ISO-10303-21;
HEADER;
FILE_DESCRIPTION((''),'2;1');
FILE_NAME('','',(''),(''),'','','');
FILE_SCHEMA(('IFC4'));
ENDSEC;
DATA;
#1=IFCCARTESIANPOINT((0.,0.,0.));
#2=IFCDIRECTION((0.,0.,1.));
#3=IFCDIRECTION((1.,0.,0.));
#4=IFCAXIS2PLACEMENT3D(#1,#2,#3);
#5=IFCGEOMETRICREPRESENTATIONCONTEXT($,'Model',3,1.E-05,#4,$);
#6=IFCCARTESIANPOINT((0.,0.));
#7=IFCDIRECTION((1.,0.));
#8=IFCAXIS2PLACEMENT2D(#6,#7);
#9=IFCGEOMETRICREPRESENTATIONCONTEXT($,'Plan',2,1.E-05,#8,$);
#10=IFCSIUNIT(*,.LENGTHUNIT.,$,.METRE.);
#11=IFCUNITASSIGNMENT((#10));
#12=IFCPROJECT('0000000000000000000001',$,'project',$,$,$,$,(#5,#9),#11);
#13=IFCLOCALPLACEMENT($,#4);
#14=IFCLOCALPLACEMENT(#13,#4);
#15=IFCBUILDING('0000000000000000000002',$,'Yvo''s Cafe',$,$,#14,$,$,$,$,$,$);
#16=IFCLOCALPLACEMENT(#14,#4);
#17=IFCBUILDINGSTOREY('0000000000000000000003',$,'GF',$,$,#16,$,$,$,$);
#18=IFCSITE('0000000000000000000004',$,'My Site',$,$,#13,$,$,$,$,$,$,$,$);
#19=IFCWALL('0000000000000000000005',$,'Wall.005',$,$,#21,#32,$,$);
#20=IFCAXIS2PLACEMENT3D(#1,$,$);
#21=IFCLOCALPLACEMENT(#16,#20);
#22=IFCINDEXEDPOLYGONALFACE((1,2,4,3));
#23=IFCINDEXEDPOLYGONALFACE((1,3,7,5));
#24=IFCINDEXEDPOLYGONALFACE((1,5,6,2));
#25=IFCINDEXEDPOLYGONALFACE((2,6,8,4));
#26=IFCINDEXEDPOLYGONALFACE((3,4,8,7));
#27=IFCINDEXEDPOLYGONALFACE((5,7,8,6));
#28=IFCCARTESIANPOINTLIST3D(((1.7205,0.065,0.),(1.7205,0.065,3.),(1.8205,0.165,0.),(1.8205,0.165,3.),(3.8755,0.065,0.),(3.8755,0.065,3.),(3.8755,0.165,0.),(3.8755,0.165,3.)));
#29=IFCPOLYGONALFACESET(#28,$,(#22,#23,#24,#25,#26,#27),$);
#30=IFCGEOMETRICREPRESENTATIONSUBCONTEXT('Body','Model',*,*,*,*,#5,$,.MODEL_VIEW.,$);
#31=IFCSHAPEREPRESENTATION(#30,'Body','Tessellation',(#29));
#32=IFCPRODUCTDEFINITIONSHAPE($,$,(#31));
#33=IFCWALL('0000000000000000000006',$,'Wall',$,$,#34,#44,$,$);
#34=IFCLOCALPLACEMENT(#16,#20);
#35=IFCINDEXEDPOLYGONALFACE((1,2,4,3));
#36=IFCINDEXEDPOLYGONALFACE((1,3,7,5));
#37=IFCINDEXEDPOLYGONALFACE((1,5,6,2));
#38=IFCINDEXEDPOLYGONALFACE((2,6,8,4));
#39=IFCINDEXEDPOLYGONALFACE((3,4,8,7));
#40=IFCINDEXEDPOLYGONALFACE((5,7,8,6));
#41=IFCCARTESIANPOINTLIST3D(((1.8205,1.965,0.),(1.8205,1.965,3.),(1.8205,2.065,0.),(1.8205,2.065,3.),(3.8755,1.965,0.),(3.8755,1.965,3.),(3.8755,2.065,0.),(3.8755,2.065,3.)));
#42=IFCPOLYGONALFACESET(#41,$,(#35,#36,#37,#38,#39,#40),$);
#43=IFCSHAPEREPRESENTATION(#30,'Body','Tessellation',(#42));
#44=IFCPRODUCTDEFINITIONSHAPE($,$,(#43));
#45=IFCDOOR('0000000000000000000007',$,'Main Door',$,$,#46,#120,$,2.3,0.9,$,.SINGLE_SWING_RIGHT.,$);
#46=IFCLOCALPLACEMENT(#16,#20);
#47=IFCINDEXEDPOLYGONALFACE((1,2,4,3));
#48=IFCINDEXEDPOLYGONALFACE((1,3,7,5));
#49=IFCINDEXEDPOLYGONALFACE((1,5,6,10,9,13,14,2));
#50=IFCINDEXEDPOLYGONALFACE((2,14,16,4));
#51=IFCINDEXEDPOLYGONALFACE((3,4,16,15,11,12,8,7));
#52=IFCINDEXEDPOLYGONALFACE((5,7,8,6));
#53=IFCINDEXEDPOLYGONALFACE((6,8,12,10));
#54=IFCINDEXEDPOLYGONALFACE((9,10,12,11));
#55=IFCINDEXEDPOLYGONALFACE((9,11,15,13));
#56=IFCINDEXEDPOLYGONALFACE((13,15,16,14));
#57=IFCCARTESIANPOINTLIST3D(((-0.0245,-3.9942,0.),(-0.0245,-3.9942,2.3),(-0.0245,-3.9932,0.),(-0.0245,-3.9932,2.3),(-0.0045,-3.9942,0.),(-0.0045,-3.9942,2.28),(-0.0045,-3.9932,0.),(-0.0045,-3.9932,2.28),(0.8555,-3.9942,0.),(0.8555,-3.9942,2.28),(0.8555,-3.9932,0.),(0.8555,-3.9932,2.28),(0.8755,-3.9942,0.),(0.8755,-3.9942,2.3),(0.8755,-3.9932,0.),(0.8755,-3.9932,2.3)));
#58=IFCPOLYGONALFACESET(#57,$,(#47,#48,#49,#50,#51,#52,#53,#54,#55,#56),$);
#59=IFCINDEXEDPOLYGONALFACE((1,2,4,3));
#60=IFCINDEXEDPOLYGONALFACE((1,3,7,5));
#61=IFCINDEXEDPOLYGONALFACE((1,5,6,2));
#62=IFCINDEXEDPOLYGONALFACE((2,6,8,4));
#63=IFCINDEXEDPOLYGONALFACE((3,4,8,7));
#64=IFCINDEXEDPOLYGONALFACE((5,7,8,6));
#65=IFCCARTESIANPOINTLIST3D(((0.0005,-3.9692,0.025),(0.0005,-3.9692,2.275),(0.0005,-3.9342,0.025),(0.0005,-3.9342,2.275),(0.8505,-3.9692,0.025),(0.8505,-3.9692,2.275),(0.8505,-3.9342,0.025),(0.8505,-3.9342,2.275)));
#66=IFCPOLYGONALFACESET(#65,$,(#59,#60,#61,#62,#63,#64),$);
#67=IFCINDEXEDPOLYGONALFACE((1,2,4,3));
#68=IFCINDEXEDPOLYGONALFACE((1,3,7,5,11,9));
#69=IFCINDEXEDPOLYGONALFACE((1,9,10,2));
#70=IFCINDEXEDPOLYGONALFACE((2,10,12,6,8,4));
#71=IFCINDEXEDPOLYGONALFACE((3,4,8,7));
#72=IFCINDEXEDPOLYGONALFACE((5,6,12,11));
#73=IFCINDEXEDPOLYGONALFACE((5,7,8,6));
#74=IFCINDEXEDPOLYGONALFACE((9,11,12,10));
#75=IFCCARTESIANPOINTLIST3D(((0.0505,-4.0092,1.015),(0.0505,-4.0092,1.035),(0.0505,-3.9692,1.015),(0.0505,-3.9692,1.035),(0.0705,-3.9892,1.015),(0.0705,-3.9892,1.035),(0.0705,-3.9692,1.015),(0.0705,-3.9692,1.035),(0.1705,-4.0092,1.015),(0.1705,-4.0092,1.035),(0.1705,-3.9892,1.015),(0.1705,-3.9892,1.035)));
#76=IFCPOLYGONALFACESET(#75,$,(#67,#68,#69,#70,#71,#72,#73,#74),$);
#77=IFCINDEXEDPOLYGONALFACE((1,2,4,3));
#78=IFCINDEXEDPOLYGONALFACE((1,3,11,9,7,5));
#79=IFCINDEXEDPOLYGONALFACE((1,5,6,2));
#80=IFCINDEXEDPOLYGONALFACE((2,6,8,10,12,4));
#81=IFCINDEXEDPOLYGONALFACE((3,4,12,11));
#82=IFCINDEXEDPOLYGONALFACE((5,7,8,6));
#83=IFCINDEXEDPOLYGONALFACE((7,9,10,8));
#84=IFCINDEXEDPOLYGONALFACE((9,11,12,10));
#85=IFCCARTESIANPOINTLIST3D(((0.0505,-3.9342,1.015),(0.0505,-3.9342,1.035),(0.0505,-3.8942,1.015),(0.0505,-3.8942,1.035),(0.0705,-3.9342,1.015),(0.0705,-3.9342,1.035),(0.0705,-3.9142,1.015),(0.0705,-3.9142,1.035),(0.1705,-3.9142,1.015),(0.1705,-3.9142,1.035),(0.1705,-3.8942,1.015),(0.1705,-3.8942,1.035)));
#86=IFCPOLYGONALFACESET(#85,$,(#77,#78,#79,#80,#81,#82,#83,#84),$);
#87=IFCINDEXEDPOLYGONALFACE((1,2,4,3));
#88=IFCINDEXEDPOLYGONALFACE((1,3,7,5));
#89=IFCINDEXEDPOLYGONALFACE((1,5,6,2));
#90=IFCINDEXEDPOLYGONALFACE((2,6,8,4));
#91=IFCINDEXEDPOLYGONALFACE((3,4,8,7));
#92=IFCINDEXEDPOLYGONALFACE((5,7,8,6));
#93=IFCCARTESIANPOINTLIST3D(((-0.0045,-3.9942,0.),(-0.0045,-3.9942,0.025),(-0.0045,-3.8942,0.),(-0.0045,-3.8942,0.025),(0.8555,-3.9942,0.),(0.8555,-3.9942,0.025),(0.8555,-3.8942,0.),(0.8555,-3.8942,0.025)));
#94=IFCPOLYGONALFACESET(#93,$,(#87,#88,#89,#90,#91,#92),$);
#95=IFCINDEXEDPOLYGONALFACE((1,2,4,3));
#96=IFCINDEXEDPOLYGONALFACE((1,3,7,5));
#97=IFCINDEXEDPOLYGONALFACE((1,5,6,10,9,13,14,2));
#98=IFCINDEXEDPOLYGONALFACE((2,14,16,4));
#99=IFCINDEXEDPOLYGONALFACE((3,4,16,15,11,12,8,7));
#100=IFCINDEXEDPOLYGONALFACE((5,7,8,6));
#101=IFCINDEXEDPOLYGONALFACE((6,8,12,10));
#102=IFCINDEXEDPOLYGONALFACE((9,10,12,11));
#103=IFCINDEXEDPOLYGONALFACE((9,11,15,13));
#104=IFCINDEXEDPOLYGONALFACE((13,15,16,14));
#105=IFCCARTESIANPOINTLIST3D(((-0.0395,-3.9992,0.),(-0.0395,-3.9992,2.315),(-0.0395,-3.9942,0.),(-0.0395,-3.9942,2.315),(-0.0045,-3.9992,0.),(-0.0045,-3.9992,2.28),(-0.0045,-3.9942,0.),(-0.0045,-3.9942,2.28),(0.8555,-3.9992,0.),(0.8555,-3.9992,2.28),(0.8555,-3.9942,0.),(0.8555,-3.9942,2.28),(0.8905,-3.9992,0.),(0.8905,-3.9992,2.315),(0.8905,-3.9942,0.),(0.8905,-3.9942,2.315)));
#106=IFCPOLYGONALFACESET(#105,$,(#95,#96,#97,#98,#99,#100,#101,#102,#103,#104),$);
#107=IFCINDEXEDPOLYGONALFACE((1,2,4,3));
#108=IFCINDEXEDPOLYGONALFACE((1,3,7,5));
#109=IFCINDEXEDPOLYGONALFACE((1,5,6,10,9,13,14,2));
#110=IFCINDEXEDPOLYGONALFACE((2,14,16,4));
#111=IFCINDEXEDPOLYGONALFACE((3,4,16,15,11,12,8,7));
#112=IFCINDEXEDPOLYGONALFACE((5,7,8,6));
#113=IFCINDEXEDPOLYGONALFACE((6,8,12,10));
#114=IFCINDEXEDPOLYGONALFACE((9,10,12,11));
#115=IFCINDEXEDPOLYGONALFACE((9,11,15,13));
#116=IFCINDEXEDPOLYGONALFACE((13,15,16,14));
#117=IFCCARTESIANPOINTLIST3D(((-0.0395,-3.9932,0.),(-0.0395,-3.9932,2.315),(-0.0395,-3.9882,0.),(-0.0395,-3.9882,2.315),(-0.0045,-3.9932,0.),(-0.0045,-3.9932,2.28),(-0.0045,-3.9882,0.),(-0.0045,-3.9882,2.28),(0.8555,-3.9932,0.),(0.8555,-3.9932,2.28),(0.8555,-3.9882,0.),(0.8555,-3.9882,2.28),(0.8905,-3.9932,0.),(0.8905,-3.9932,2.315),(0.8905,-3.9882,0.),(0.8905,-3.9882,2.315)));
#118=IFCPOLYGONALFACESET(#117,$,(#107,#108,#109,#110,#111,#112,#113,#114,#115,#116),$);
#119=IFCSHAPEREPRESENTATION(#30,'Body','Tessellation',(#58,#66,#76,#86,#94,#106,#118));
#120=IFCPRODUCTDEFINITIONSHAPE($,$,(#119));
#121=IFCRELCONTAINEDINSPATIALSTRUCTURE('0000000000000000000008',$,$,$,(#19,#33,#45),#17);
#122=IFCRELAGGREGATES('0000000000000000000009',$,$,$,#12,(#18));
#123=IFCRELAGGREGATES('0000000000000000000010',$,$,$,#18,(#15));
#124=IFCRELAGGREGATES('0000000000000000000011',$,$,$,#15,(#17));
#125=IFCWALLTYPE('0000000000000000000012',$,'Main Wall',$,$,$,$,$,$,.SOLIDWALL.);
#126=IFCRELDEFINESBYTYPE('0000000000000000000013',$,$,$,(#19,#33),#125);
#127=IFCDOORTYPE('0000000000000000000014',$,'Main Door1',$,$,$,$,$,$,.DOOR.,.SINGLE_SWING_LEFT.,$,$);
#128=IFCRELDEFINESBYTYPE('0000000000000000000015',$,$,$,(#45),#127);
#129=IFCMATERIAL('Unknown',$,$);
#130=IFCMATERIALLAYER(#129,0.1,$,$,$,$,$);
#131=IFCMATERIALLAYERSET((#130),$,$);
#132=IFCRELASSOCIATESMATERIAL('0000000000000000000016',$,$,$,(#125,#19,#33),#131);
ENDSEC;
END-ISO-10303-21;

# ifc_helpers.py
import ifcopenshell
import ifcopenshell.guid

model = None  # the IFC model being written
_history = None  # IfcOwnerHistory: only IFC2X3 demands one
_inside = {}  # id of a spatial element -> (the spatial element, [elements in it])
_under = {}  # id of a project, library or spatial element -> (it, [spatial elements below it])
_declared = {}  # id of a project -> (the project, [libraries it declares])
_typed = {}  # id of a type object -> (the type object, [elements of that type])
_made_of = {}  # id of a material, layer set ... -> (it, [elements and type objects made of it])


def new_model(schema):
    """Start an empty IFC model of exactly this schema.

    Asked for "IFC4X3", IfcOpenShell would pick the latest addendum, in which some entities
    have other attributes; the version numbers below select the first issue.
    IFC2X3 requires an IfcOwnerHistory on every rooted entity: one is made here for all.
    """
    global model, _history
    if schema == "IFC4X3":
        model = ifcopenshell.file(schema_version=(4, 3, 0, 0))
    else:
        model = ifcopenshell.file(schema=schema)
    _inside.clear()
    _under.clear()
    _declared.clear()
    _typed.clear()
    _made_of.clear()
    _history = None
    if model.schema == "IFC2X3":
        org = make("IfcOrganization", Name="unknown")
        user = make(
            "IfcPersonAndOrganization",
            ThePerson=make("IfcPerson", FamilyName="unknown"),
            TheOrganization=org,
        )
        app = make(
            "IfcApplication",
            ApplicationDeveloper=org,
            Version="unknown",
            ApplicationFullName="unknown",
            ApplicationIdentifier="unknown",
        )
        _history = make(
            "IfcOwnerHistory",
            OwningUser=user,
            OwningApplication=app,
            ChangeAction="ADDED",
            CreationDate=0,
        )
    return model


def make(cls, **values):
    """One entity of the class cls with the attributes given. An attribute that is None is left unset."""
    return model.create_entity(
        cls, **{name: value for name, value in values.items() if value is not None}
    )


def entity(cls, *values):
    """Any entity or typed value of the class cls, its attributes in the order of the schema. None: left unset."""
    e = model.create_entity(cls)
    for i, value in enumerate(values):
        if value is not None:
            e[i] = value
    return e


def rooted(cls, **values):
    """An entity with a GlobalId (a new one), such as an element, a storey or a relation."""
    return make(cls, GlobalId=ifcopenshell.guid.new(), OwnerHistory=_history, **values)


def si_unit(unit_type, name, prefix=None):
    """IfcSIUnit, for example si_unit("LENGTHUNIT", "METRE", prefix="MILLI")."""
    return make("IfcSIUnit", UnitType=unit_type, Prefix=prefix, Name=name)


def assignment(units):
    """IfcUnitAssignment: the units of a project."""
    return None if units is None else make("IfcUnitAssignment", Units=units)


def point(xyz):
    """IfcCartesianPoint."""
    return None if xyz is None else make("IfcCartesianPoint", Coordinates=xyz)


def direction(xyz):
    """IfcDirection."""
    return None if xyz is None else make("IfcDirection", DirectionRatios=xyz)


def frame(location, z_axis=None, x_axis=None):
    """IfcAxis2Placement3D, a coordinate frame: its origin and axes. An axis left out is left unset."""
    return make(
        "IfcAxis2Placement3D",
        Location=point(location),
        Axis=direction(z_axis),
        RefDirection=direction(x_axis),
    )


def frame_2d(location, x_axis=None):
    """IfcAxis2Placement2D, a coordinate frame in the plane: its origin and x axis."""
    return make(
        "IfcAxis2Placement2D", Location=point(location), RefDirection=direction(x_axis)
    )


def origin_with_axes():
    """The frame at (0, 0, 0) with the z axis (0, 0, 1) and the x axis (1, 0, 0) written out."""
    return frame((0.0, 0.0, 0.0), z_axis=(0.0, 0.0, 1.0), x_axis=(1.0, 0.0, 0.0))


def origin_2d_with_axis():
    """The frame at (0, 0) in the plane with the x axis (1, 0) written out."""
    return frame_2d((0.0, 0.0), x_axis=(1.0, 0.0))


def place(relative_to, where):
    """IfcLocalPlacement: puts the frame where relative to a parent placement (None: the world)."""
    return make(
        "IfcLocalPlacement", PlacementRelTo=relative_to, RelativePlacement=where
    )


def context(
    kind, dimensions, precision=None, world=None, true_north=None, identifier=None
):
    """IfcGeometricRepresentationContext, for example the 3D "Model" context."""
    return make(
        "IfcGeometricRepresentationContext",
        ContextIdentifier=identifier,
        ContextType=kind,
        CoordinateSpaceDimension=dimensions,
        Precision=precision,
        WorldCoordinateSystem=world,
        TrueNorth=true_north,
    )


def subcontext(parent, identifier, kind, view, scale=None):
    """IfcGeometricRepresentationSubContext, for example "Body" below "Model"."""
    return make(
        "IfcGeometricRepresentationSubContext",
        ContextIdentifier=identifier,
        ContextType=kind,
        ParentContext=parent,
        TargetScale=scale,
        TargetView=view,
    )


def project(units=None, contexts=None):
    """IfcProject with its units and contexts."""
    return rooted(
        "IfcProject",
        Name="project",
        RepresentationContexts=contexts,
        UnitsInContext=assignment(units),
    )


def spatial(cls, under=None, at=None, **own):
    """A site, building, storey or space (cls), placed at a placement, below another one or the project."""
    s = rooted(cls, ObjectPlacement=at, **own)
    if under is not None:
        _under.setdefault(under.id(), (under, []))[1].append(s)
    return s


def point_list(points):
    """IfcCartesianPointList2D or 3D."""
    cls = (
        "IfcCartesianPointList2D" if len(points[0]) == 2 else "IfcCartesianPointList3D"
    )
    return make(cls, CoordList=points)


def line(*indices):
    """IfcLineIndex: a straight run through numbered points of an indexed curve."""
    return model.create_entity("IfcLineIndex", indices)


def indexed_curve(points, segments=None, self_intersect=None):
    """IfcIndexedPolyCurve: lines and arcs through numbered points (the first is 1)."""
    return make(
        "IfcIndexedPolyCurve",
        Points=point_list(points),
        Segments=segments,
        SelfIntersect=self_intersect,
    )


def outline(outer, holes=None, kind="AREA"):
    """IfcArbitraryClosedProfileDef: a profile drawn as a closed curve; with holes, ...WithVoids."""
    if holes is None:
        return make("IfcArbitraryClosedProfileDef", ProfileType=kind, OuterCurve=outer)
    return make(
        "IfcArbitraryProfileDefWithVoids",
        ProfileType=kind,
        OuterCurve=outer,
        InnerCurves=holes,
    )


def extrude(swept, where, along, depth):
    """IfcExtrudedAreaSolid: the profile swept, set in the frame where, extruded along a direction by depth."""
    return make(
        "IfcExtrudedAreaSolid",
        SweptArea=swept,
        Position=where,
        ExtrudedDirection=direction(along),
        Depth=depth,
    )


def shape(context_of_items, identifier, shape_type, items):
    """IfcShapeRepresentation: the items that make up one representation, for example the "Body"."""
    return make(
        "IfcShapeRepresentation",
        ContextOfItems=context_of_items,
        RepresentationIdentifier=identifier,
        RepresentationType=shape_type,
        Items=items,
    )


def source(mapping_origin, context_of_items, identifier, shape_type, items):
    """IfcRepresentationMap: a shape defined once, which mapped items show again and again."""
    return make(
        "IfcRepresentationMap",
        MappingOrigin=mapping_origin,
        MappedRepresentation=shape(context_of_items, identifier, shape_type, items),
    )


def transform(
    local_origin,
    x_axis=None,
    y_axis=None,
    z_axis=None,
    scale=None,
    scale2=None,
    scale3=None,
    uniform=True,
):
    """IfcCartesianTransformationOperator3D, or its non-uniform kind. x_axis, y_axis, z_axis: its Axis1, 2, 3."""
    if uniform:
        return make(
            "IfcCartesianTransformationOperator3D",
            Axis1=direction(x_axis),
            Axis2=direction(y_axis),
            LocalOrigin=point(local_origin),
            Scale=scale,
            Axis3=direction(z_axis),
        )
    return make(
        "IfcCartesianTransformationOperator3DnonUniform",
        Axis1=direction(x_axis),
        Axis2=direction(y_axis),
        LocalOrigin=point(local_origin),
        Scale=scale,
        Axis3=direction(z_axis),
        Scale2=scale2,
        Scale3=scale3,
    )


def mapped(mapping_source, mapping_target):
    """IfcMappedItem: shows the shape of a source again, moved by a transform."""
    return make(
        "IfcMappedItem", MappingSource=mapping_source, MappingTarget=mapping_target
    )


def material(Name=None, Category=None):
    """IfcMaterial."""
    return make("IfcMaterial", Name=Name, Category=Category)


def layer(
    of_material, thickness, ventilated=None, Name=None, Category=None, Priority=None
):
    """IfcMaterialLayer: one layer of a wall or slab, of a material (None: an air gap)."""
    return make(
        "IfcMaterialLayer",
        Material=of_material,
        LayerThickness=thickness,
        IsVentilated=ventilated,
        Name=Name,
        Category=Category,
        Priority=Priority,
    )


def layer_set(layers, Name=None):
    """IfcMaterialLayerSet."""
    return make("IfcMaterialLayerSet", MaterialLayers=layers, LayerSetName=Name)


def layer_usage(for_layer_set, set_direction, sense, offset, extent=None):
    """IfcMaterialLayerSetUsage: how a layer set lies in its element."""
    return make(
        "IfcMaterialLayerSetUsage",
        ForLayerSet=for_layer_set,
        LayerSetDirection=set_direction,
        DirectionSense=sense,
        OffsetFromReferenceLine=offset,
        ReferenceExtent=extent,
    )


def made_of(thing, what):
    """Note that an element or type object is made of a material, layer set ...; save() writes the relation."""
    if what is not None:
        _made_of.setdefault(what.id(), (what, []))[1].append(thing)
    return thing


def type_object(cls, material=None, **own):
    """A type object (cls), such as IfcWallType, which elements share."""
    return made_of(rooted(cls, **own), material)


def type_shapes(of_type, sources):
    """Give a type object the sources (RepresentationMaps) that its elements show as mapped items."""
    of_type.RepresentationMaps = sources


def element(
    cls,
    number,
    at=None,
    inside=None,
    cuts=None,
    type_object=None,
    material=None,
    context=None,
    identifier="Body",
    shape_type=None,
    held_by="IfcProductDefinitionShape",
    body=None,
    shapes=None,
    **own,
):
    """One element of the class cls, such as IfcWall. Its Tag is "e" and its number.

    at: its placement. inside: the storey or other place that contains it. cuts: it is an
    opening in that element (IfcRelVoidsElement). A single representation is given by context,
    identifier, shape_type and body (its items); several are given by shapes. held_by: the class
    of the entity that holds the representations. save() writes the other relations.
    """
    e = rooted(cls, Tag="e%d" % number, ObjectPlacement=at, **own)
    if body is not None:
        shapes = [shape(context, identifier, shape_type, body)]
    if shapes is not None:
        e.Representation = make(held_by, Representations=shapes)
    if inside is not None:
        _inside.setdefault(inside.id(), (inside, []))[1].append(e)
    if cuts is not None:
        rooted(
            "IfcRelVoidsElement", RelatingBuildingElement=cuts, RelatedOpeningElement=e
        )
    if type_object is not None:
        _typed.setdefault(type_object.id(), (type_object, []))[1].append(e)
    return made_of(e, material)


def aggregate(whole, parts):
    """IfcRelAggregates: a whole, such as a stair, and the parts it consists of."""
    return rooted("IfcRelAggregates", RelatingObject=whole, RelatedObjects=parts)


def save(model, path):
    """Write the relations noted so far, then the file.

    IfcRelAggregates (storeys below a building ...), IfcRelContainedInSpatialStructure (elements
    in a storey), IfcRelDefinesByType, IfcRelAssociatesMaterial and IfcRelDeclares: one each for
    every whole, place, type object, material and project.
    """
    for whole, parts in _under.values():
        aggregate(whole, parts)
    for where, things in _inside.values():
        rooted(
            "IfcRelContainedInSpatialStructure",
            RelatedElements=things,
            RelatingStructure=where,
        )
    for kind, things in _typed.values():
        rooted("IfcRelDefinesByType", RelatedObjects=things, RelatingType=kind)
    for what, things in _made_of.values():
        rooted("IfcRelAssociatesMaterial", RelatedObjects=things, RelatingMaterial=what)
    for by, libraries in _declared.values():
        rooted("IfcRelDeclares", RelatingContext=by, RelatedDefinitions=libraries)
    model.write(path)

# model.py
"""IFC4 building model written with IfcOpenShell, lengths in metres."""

from ifc_helpers import new_model, entity, si_unit, frame, origin_with_axes, origin_2d_with_axis, place, context, subcontext, project, spatial, line, indexed_curve, outline, extrude, shape, source, transform, mapped, material, layer, layer_set, layer_usage, type_object, type_shapes, element, save


model = new_model("IFC4")

# Units and contexts
model_context = context("Model", 3, precision=1e-05, world=origin_with_axes())
plan_context = context("Plan", 2, precision=1e-05, world=origin_2d_with_axis())
body_context_1 = subcontext(model_context, "Body", "Model", "MODEL_VIEW")
body_context_2 = subcontext(plan_context, "Body", "Plan", "PLAN_VIEW")
ifc_project = project(units=[si_unit("LENGTHUNIT", "METRE")], contexts=[model_context, plan_context])

# Site, building, storey
site_placement = place(None, origin_with_axes())
site = spatial("IfcSite", under=ifc_project, at=site_placement, Name="My Site")
building_placement = place(site_placement, origin_with_axes())
building = spatial("IfcBuilding", under=site, at=building_placement, Name="Yvo's Cafe")
storey_placement = place(building_placement, origin_with_axes())
storey = spatial("IfcBuildingStorey", under=building, at=storey_placement, Name="GF")

# Shared definitions
ifc_material = material(Name="Unknown")

# Shared definitions
ifc_layer_1 = layer(ifc_material, 0.1)
ifc_layer_set_1 = layer_set([ifc_layer_1])
wall_type = type_object("IfcWallType", Name="Main Wall", PredefinedType="SOLIDWALL", material=ifc_layer_set_1)

# Walls
ifc_layer_usage_1 = layer_usage(ifc_layer_set_1, "AXIS2", "POSITIVE", 0.0)
wall_1_placement = place(storey_placement, frame((1.7205, 0.065, 0.0), z_axis=(0.0, 0.0, 1.0), x_axis=(1.0, 0.0, 0.0)))
element("IfcWall", 1, at=wall_1_placement, inside=storey, type_object=wall_type, material=ifc_layer_usage_1, Name="Wall.005", context=body_context_1, shape_type="SweptSolid", body=[
    extrude(outline(indexed_curve([(0.0, 0.0), (0.1, 0.1), (2.155, 0.1), (2.155, 0.0)], segments=[line(1, 2, 3, 4, 1)])), origin_with_axes(), (0.0, 0.0, 1.0), 3.0),
])
ifc_layer_usage_2 = layer_usage(ifc_layer_set_1, "AXIS2", "POSITIVE", 0.0)
wall_2_placement = place(storey_placement, frame((1.8205, 1.965, 0.0), z_axis=(0.0, 0.0, 1.0), x_axis=(1.0, 0.0, 0.0)))
element("IfcWall", 2, at=wall_2_placement, inside=storey, type_object=wall_type, material=ifc_layer_usage_2, Name="Wall", context=body_context_1, shape_type="SweptSolid", body=[
    extrude(outline(indexed_curve([(0.0, 0.0), (0.0, 0.1), (2.055, 0.1), (2.055, 0.0)], segments=[line(1, 2, 3, 4, 1)])), origin_with_axes(), (0.0, 0.0, 1.0), 3.0),
])

# Door
door_type_1 = type_object("IfcDoorType", Name="Main Door1", OperationType="SINGLE_SWING_LEFT", PredefinedType="DOOR")
shared_shape_1 = source(origin_with_axes(), body_context_1, "Body", "SweptSolid", [
    extrude(outline(indexed_curve([(0.0, 0.0), (0.0, 2.3), (0.9, 2.3), (0.9, 0.0), (0.88, 0.0), (0.88, 2.28), (0.02, 2.28), (0.02, 0.0)], segments=[line(1, 2, 3, 4, 5, 6, 7, 8, 1)])), frame((0.0, 0.0, 0.0), z_axis=(0.0, -1.0, 0.0), x_axis=(1.0, 0.0, 0.0)), (0.0, 0.0, -1.0), 0.001),
    extrude(outline(indexed_curve([(0.0, 0.0), (0.85, 0.0), (0.85, 0.035), (0.0, 0.035)], segments=[line(1, 2, 3, 4, 1)])), frame((0.025, 0.025, 0.025), z_axis=(0.0, 0.0, 1.0), x_axis=(1.0, 0.0, 0.0)), (0.0, 0.0, 1.0), 2.25),
    extrude(outline(indexed_curve([(0.0, 0.0), (0.0, -0.04), (0.12, -0.04), (0.12, -0.02), (0.02, -0.02), (0.02, 0.0)], segments=[line(1, 2, 3, 4, 5, 6, 1)])), frame((0.075, 0.025, 1.015), z_axis=(0.0, 0.0, 1.0), x_axis=(1.0, 0.0, 0.0)), (0.0, 0.0, 1.0), 0.02),
    extrude(outline(indexed_curve([(0.0, 0.0), (0.0, 0.04), (0.12, 0.04), (0.12, 0.02), (0.02, 0.02), (0.02, 0.0)], segments=[line(1, 2, 3, 4, 5, 6, 1)])), frame((0.075, 0.06, 1.015), z_axis=(0.0, 0.0, 1.0), x_axis=(1.0, 0.0, 0.0)), (0.0, 0.0, 1.0), 0.02),
    extrude(outline(indexed_curve([(0.0, 0.0), (0.86, 0.0), (0.86, 0.1), (0.0, 0.1)], segments=[line(1, 2, 3, 4, 1)])), frame((0.02, 0.0, 0.0), z_axis=(0.0, 0.0, 1.0), x_axis=(1.0, 0.0, 0.0)), (0.0, 0.0, 1.0), 0.025),
    extrude(outline(indexed_curve([(0.0, 0.0), (0.0, 2.315), (0.93, 2.315), (0.93, 0.0), (0.895, 0.0), (0.895, 2.28), (0.035, 2.28), (0.035, 0.0)], segments=[line(1, 2, 3, 4, 5, 6, 7, 8, 1)])), frame((-0.015, -0.005, 0.0), z_axis=(0.0, -1.0, 0.0), x_axis=(1.0, 0.0, 0.0)), (0.0, 0.0, -1.0), 0.005),
    extrude(outline(indexed_curve([(0.0, 0.0), (0.0, 2.315), (0.93, 2.315), (0.93, 0.0), (0.895, 0.0), (0.895, 2.28), (0.035, 2.28), (0.035, 0.0)], segments=[line(1, 2, 3, 4, 5, 6, 7, 8, 1)])), frame((-0.015, 0.001, 0.0), z_axis=(0.0, -1.0, 0.0), x_axis=(1.0, 0.0, 0.0)), (0.0, 0.0, -1.0), 0.005),
])
shared_shape_2 = source(origin_with_axes(), body_context_2, "Body", "Curve2D", [
    entity("IfcIndexedPolyCurve", entity("IfcCartesianPointList2D", [[0.0, 0.0], [0.02, 0.0], [0.02, 0.001], [0.0, 0.001]]), [entity("IfcLineIndex", [1, 2, 3, 4, 1])]),
    entity("IfcIndexedPolyCurve", entity("IfcCartesianPointList2D", [[0.9, 0.0], [0.88, 0.0], [0.88, 0.001], [0.9, 0.001]]), [entity("IfcLineIndex", [1, 2, 3, 4, 1])]),
    entity("IfcTrimmedCurve", entity("IfcEllipse", entity("IfcAxis2Placement2D", entity("IfcCartesianPoint", [0.84, 0.001]), entity("IfcDirection", [1.0, 0.0])), 0.815, 0.85), [entity("IfcCartesianPoint", [0.84, 0.851])], [entity("IfcCartesianPoint", [0.025, 0.001])], True, "CARTESIAN"),
    entity("IfcIndexedPolyCurve", entity("IfcCartesianPointList2D", [[0.875, 0.001], [0.84, 0.001], [0.84, 0.851], [0.875, 0.851]]), [entity("IfcLineIndex", [1, 2, 3, 4, 1])]),
])
type_shapes(door_type_1, [shared_shape_1, shared_shape_2])
door_1_placement = place(storey_placement, frame((-0.0245, -3.9942, 0.0), z_axis=(0.0, 0.0, 1.0), x_axis=(1.0, 0.0, 0.0)))
element("IfcDoor", 3, at=door_1_placement, inside=storey, type_object=door_type_1, Name="Main Door", OperationType="SINGLE_SWING_RIGHT", OverallHeight=2.3, OverallWidth=0.9, shapes=[
    shape(body_context_1, "Body", "MappedRepresentation", [mapped(shared_shape_1, transform((0.0, 0.0, 0.0), x_axis=(1.0, 0.0, 0.0), y_axis=(0.0, 1.0, 0.0), z_axis=(0.0, 0.0, 1.0), scale=1.0))]),
    shape(body_context_2, "Body", "MappedRepresentation", [mapped(shared_shape_2, transform((0.0, 0.0, 0.0), x_axis=(1.0, 0.0, 0.0), y_axis=(0.0, 1.0, 0.0), z_axis=(0.0, 0.0, 1.0), scale=1.0))]),
])

save(model, "model.ifc")
